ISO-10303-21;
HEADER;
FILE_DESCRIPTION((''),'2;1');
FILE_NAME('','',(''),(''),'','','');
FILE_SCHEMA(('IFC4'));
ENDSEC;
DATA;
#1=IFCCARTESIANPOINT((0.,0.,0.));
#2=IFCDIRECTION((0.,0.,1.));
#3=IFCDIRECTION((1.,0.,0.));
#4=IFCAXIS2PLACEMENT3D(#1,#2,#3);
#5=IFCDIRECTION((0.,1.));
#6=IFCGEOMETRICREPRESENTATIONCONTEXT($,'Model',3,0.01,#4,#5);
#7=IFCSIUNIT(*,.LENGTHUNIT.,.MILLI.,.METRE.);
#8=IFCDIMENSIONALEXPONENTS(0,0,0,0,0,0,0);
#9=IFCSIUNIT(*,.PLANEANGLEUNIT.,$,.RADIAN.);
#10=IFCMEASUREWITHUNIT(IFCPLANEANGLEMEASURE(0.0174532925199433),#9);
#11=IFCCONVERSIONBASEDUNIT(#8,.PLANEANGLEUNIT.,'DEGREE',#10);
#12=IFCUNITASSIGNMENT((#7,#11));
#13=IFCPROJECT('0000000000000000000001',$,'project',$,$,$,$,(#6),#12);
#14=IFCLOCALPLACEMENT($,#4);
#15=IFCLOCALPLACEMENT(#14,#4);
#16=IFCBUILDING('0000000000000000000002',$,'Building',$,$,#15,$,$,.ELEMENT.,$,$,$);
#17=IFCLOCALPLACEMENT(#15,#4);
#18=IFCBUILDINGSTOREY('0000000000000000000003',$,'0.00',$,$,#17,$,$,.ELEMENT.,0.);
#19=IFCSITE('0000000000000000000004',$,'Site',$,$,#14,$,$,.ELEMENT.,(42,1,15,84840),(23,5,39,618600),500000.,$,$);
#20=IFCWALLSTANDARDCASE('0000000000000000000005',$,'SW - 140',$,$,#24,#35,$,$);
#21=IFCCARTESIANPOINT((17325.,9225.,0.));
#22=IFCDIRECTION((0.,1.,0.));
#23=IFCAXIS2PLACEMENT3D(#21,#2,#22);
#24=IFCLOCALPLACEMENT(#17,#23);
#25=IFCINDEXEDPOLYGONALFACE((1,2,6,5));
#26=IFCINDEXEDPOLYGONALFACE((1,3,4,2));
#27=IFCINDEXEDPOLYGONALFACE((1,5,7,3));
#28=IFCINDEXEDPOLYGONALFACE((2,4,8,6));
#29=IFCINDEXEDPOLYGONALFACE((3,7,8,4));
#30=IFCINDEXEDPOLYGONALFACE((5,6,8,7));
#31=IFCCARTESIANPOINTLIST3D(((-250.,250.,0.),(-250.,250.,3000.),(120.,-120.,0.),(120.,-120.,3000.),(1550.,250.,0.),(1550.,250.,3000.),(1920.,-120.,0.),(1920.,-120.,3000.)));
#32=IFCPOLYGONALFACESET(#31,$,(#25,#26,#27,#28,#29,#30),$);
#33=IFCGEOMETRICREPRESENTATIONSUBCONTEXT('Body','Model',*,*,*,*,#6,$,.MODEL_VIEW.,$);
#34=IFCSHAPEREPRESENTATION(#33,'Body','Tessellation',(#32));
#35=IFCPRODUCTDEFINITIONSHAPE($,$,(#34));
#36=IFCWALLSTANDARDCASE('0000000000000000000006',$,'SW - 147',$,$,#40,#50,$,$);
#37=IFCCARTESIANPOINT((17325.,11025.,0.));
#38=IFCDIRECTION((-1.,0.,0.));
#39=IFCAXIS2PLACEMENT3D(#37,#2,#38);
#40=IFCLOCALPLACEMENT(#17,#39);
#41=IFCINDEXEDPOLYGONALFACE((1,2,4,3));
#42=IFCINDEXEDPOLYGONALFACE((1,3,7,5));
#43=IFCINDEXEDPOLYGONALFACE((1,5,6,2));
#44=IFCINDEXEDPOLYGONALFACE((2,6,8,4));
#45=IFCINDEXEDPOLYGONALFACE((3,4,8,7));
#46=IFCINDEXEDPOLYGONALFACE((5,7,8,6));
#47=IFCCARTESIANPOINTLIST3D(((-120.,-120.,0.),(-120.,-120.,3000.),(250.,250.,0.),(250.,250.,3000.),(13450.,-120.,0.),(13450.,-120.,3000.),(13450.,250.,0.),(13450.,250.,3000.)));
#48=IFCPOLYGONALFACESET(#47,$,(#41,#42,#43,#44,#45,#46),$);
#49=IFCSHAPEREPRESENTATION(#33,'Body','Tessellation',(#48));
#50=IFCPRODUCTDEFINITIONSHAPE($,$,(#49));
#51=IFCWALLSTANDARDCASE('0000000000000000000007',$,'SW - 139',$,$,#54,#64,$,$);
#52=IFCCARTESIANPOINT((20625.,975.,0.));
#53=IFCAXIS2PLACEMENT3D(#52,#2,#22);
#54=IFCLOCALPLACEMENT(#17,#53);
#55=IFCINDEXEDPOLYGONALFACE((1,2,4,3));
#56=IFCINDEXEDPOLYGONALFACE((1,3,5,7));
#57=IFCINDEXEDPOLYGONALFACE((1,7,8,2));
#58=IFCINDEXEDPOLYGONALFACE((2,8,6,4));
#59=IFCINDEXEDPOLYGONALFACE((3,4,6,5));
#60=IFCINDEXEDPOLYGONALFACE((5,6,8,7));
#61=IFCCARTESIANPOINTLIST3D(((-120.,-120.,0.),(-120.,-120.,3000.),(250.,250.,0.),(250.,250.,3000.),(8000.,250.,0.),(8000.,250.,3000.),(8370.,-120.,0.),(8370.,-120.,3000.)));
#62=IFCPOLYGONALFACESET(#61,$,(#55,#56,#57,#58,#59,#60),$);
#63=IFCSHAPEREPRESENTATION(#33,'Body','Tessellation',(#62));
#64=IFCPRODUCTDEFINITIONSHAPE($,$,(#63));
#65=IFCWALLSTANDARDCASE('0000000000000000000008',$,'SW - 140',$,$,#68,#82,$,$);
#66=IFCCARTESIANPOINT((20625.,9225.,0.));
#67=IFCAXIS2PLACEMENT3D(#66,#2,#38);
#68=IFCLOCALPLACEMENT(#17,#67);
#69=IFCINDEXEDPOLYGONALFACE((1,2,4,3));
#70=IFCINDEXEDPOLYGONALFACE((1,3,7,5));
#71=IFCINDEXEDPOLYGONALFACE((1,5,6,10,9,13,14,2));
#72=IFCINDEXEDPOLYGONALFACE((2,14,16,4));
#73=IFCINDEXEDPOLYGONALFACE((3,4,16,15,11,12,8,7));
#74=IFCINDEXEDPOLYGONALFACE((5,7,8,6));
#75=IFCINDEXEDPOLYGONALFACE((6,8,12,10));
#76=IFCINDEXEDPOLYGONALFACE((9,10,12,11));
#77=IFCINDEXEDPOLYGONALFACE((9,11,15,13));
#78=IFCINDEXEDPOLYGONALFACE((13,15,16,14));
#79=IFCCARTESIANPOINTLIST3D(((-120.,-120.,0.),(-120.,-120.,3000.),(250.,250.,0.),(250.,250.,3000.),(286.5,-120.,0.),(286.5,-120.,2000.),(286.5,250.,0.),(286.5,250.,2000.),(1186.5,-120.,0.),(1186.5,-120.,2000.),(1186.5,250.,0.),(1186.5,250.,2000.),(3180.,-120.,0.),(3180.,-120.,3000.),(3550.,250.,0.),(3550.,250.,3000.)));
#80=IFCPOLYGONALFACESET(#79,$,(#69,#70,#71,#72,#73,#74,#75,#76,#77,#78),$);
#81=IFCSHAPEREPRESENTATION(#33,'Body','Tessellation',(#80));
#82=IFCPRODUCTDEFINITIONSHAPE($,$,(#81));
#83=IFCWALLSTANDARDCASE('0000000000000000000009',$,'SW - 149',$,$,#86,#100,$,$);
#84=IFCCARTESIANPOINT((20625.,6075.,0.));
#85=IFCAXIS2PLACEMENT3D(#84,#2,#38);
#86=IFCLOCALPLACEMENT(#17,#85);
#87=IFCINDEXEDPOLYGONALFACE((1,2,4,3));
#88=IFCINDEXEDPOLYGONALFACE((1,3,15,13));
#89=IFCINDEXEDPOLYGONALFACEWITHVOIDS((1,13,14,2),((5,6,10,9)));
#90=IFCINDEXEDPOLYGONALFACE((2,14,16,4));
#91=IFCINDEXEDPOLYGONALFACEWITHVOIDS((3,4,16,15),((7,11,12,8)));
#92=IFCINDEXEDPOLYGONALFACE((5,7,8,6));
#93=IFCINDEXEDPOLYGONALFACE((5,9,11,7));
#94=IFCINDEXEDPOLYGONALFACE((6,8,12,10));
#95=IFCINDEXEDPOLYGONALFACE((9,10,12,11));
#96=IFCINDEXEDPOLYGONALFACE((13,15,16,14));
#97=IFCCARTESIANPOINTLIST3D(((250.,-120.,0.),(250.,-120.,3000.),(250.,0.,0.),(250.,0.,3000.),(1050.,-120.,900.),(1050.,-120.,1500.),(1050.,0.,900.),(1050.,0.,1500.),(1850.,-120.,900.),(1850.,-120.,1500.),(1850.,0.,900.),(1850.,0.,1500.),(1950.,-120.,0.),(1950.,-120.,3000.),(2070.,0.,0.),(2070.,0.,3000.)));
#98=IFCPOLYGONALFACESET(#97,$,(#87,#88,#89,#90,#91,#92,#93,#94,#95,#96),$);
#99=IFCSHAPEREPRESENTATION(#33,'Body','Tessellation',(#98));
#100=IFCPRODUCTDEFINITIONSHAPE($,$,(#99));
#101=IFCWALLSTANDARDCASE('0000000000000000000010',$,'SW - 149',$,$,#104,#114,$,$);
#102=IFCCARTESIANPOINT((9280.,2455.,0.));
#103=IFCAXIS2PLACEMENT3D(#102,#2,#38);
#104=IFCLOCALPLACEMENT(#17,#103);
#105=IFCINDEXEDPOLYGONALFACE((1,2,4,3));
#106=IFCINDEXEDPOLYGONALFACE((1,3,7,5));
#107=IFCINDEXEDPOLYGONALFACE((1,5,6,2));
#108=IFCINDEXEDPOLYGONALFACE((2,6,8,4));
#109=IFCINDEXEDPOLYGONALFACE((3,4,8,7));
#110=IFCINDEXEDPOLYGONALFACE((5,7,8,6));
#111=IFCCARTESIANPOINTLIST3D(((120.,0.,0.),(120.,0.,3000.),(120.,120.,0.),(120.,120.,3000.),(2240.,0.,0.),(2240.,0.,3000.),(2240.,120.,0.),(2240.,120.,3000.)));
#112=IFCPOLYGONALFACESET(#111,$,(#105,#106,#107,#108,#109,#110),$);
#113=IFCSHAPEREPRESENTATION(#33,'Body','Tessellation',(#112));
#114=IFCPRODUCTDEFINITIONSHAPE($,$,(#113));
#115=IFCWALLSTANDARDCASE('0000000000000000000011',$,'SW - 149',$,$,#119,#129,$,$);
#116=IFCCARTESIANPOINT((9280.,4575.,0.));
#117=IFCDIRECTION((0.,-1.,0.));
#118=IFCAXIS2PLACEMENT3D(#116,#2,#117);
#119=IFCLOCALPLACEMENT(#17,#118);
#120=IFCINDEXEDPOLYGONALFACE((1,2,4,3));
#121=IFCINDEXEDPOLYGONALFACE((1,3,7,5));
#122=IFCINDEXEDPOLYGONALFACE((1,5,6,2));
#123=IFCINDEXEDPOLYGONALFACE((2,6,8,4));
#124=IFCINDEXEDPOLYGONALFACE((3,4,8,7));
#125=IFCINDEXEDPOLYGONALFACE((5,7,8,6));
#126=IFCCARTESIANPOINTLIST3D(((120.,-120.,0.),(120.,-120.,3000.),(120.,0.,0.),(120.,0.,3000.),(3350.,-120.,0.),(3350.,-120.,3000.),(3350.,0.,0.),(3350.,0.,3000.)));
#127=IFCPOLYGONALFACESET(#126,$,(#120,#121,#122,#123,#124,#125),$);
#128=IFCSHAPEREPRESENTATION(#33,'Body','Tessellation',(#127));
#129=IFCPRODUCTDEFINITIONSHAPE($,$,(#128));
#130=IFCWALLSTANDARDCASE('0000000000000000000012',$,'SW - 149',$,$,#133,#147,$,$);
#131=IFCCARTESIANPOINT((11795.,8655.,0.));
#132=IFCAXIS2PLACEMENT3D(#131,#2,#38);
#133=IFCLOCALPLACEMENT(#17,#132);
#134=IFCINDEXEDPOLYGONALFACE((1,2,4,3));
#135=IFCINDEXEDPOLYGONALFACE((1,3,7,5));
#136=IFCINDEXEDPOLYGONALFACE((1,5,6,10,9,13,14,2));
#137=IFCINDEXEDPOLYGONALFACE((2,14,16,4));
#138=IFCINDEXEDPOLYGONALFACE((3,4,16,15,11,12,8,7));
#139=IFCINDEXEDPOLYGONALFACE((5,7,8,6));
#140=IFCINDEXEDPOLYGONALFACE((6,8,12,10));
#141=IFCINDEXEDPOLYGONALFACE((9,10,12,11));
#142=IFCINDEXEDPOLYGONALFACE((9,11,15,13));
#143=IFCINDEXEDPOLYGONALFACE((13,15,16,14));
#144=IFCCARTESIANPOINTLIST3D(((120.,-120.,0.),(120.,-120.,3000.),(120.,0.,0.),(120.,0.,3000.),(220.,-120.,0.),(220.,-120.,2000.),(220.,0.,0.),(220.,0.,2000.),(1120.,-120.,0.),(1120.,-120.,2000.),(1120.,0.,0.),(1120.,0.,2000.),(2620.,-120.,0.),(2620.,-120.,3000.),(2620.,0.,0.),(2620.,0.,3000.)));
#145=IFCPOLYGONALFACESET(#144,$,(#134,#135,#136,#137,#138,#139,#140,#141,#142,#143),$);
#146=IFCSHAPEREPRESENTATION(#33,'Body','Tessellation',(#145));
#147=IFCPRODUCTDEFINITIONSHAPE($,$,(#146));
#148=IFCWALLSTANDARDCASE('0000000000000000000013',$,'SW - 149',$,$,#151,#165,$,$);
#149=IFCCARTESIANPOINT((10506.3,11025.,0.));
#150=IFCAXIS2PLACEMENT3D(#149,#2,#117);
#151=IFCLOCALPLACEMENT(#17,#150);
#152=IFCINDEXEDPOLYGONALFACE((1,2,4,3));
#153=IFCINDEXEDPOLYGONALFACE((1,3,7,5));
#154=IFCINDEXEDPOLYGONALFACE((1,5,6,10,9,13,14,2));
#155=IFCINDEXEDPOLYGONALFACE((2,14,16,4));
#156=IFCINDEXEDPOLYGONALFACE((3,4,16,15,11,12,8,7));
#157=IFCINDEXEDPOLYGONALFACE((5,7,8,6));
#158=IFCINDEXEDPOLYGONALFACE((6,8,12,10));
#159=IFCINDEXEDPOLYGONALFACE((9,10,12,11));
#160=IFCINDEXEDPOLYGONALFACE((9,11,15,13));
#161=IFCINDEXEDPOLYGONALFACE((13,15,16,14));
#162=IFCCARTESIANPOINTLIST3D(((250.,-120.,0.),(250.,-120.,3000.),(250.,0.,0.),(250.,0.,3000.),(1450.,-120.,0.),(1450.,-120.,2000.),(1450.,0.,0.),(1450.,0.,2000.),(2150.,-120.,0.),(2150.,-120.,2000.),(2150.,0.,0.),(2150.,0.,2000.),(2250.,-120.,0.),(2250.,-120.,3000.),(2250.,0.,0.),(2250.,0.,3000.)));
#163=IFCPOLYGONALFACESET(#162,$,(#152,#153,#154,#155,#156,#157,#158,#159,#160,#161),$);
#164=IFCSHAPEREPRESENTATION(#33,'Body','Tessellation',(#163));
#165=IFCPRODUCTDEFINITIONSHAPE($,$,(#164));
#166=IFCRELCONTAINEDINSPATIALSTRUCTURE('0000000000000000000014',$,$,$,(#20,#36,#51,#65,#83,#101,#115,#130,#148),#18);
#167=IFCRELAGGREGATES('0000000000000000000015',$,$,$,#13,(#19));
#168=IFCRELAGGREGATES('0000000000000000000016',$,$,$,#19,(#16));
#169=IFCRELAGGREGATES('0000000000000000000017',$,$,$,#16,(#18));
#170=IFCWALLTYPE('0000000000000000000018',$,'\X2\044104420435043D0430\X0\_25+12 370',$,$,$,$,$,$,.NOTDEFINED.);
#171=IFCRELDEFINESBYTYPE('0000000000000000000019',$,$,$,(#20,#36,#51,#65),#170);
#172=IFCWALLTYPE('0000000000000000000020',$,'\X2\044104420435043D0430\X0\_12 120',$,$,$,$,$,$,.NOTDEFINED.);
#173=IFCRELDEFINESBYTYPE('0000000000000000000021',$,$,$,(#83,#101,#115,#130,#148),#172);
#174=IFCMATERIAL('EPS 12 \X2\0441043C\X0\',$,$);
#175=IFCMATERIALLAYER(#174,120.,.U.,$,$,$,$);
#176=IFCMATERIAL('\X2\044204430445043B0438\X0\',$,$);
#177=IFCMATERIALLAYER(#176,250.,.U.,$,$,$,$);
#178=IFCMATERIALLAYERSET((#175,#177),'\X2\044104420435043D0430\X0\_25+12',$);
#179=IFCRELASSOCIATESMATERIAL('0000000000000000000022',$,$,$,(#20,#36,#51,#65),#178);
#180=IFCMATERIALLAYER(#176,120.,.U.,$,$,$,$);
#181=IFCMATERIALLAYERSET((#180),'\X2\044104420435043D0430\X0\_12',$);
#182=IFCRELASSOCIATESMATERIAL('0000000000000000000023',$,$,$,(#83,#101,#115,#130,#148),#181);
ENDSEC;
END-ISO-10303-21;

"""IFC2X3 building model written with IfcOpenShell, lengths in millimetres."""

from ifc_helpers import new_model, entity, si_unit, converted_unit, direction, frame, origin_with_axes, origin_2d_with_axis, place, context, subcontext, project, spatial, polyline, rectangle, outline, extrude, material, layer, layer_set, layer_usage, type_object, element, save


model = new_model("IFC2X3")

# Units and contexts
model_context = context("Model", 3, precision=0.01, world=origin_with_axes(), true_north=direction((0.0, 1.0)))
body_context = subcontext(model_context, "Body", "Model", "MODEL_VIEW")
ifc_project = project(units=[si_unit("LENGTHUNIT", "METRE", prefix="MILLI"), converted_unit("PLANEANGLEUNIT", "DEGREE", entity("IfcPlaneAngleMeasure", 0.0174532925199433), si_unit("PLANEANGLEUNIT", "RADIAN"), dimensions=[0, 0, 0, 0, 0, 0, 0])], contexts=[model_context])

# Site, building, storey
site_placement = place(None, origin_with_axes())
site = spatial("IfcSite", under=ifc_project, at=site_placement, Name="Site", CompositionType="ELEMENT", RefLatitude=(42, 1, 15, 84840), RefLongitude=(23, 5, 39, 618600), RefElevation=500000.0)
building_placement = place(site_placement, origin_with_axes())
building = spatial("IfcBuilding", under=site, at=building_placement, Name="Building", CompositionType="ELEMENT")
storey_placement = place(building_placement, origin_with_axes())
storey = spatial("IfcBuildingStorey", under=building, at=storey_placement, Name="0.00", CompositionType="ELEMENT", Elevation=0.0)

# Walls
ifc_material_1 = material(Name="EPS 12 см")
ifc_layer_1 = layer(ifc_material_1, 120.0, ventilated="UNKNOWN")
ifc_material_2 = material(Name="тухли")
ifc_layer_2 = layer(ifc_material_2, 250.0, ventilated="UNKNOWN")
ifc_layer_set_1 = layer_set([ifc_layer_1, ifc_layer_2], Name="стена_25+12")
ifc_layer_usage_1 = layer_usage(ifc_layer_set_1, "AXIS2", "POSITIVE", -120.0)
wall_type_1 = type_object("IfcWallType", Name="стена_25+12 370", PredefinedType="NOTDEFINED")
wall_1_placement = place(storey_placement, frame((17325.0, 9225.0, 0.0), z_axis=(0.0, 0.0, 1.0), x_axis=(0.0, 1.0, 0.0)))
element("IfcWallStandardCase", 1, at=wall_1_placement, inside=storey, type_object=wall_type_1, material=ifc_layer_usage_1, Name="SW - 140", context=body_context, shape_type="SweptSolid", body=[
    extrude(outline(polyline([(120.0, -120.0), (1920.0, -120.0), (1550.0, 250.0), (-250.0, 250.0), (120.0, -120.0)])), origin_with_axes(), (0.0, 0.0, 1.0), 3000.0),
])
ifc_layer_usage_2 = layer_usage(ifc_layer_set_1, "AXIS2", "POSITIVE", -120.0)
wall_2_placement = place(storey_placement, frame((17325.0, 11025.0, 0.0), z_axis=(0.0, 0.0, 1.0), x_axis=(-1.0, 0.0, 0.0)))
element("IfcWallStandardCase", 2, at=wall_2_placement, inside=storey, type_object=wall_type_1, material=ifc_layer_usage_2, Name="SW - 147", context=body_context, shape_type="SweptSolid", body=[
    extrude(outline(polyline([(-120.0, -120.0), (13450.0, -120.0), (13450.0, 250.0), (250.0, 250.0), (-120.0, -120.0)])), origin_with_axes(), (0.0, 0.0, 1.0), 3000.0),
])
ifc_layer_usage_3 = layer_usage(ifc_layer_set_1, "AXIS2", "POSITIVE", -120.0)
wall_3_placement = place(storey_placement, frame((20625.0, 975.0, 0.0), z_axis=(0.0, 0.0, 1.0), x_axis=(0.0, 1.0, 0.0)))
element("IfcWallStandardCase", 3, at=wall_3_placement, inside=storey, type_object=wall_type_1, material=ifc_layer_usage_3, Name="SW - 139", context=body_context, shape_type="SweptSolid", body=[
    extrude(outline(polyline([(-120.0, -120.0), (8370.0, -120.0), (8000.0, 250.0), (250.0, 250.0), (-120.0, -120.0)])), origin_with_axes(), (0.0, 0.0, 1.0), 3000.0),
])

# Wall, opening
ifc_layer_usage_4 = layer_usage(ifc_layer_set_1, "AXIS2", "POSITIVE", -120.0)
wall_4_placement = place(storey_placement, frame((20625.0, 9225.0, 0.0), z_axis=(0.0, 0.0, 1.0), x_axis=(-1.0, 0.0, 0.0)))
wall_4 = element("IfcWallStandardCase", 4, at=wall_4_placement, inside=storey, type_object=wall_type_1, material=ifc_layer_usage_4, Name="SW - 140", context=body_context, shape_type="SweptSolid", body=[
    extrude(outline(polyline([(-120.0, -120.0), (3180.0, -120.0), (3550.0, 250.0), (250.0, 250.0), (-120.0, -120.0)])), origin_with_axes(), (0.0, 0.0, 1.0), 3000.0),
])
opening_1_placement = place(wall_4_placement, frame((736.5, 0.0, 0.0), z_axis=(0.0, 0.0, 1.0), x_axis=(1.0, 0.0, 0.0)))
element("IfcOpeningElement", 5, at=opening_1_placement, cuts=wall_4, context=body_context, shape_type="SweptSolid", body=[
    extrude(rectangle(XDim=900.0, YDim=2000.0, at=origin_2d_with_axis()), frame((0.0, -370.0, 1000.0), z_axis=(0.0, -1.0, 0.0), x_axis=(-1.0, 0.0, 0.0)), (0.0, 0.0, -1.0), 1110.0),
])

# Wall, opening
ifc_layer_3 = layer(ifc_material_2, 120.0, ventilated="UNKNOWN")
ifc_layer_set_2 = layer_set([ifc_layer_3], Name="стена_12")
ifc_layer_usage_5 = layer_usage(ifc_layer_set_2, "AXIS2", "NEGATIVE", 0.0)
wall_type_2 = type_object("IfcWallType", Name="стена_12 120", PredefinedType="NOTDEFINED")
wall_5_placement = place(storey_placement, frame((20625.0, 6075.0, 0.0), z_axis=(0.0, 0.0, 1.0), x_axis=(-1.0, 0.0, 0.0)))
wall_5 = element("IfcWallStandardCase", 6, at=wall_5_placement, inside=storey, type_object=wall_type_2, material=ifc_layer_usage_5, Name="SW - 149", context=body_context, shape_type="SweptSolid", body=[
    extrude(outline(polyline([(250.0, -120.0), (1950.0, -120.0), (2070.0, 0.0), (250.0, 0.0), (250.0, -120.0)])), origin_with_axes(), (0.0, 0.0, 1.0), 3000.0),
])
opening_2_placement = place(wall_5_placement, frame((1450.0, 0.0, 900.0), z_axis=(0.0, 0.0, 1.0), x_axis=(1.0, 0.0, 0.0)))
element("IfcOpeningElement", 7, at=opening_2_placement, cuts=wall_5, context=body_context, shape_type="SweptSolid", body=[
    extrude(rectangle(XDim=800.0, YDim=600.0, at=origin_2d_with_axis()), frame((0.0, -120.0, 300.0), z_axis=(0.0, 1.0, 0.0), x_axis=(-1.0, 0.0, 0.0)), (0.0, 0.0, 1.0), 360.0),
])

# Wall
ifc_layer_usage_6 = layer_usage(ifc_layer_set_2, "AXIS2", "POSITIVE", 0.0)
wall_6_placement = place(storey_placement, frame((9280.0, 2455.0, 0.0), z_axis=(0.0, 0.0, 1.0), x_axis=(-1.0, 0.0, 0.0)))
element("IfcWallStandardCase", 8, at=wall_6_placement, inside=storey, type_object=wall_type_2, material=ifc_layer_usage_6, Name="SW - 149", context=body_context, shape_type="SweptSolid", body=[
    extrude(outline(polyline([(120.0, 0.0), (2240.0, 0.0), (2240.0, 120.0), (120.0, 120.0), (120.0, 0.0)])), origin_with_axes(), (0.0, 0.0, 1.0), 3000.0),
])

# Wall
ifc_layer_usage_7 = layer_usage(ifc_layer_set_2, "AXIS2", "NEGATIVE", 0.0)
wall_7_placement = place(storey_placement, frame((9280.0, 4575.0, 0.0), z_axis=(0.0, 0.0, 1.0), x_axis=(0.0, -1.0, 0.0)))
element("IfcWallStandardCase", 9, at=wall_7_placement, inside=storey, type_object=wall_type_2, material=ifc_layer_usage_7, Name="SW - 149", context=body_context, shape_type="SweptSolid", body=[
    extrude(outline(polyline([(120.0, -120.0), (3350.0, -120.0), (3350.0, 0.0), (120.0, 0.0), (120.0, -120.0)])), origin_with_axes(), (0.0, 0.0, 1.0), 3000.0),
])

# Walls, openings
ifc_layer_usage_8 = layer_usage(ifc_layer_set_2, "AXIS2", "NEGATIVE", 0.0)
wall_8_placement = place(storey_placement, frame((11795.0, 8655.0, 0.0), z_axis=(0.0, 0.0, 1.0), x_axis=(-1.0, 0.0, 0.0)))
wall_8 = element("IfcWallStandardCase", 10, at=wall_8_placement, inside=storey, type_object=wall_type_2, material=ifc_layer_usage_8, Name="SW - 149", context=body_context, shape_type="SweptSolid", body=[
    extrude(outline(polyline([(120.0, -120.0), (2620.0, -120.0), (2620.0, 0.0), (120.0, 0.0), (120.0, -120.0)])), origin_with_axes(), (0.0, 0.0, 1.0), 3000.0),
])
opening_3_placement = place(wall_8_placement, frame((670.0, 0.0, 0.0), z_axis=(0.0, 0.0, 1.0), x_axis=(1.0, 0.0, 0.0)))
element("IfcOpeningElement", 11, at=opening_3_placement, cuts=wall_8, context=body_context, shape_type="SweptSolid", body=[
    extrude(rectangle(XDim=900.0, YDim=2000.0, at=origin_2d_with_axis()), frame((0.0, -120.0, 1000.0), z_axis=(0.0, -1.0, 0.0), x_axis=(-1.0, 0.0, 0.0)), (0.0, 0.0, -1.0), 360.0),
])
ifc_layer_usage_9 = layer_usage(ifc_layer_set_2, "AXIS2", "NEGATIVE", 0.0)
wall_9_placement = place(storey_placement, frame((10506.3, 11025.0, 0.0), z_axis=(0.0, 0.0, 1.0), x_axis=(0.0, -1.0, 0.0)))
wall_9 = element("IfcWallStandardCase", 12, at=wall_9_placement, inside=storey, type_object=wall_type_2, material=ifc_layer_usage_9, Name="SW - 149", context=body_context, shape_type="SweptSolid", body=[
    extrude(outline(polyline([(250.0, -120.0), (2250.0, -120.0), (2250.0, 0.0), (250.0, 0.0), (250.0, -120.0)])), origin_with_axes(), (0.0, 0.0, 1.0), 3000.0),
])
opening_4_placement = place(wall_9_placement, frame((1800.0, 0.0, 0.0), z_axis=(0.0, 0.0, 1.0), x_axis=(1.0, 0.0, 0.0)))
element("IfcOpeningElement", 13, at=opening_4_placement, cuts=wall_9, context=body_context, shape_type="SweptSolid", body=[
    extrude(rectangle(XDim=700.0, YDim=2000.0, at=origin_2d_with_axis()), frame((0.0, 120.0, 1000.0), z_axis=(0.0, 1.0, 0.0), x_axis=(1.0, 0.0, 0.0)), (0.0, 0.0, -1.0), 360.0),
])

save(model, "model.ifc")
